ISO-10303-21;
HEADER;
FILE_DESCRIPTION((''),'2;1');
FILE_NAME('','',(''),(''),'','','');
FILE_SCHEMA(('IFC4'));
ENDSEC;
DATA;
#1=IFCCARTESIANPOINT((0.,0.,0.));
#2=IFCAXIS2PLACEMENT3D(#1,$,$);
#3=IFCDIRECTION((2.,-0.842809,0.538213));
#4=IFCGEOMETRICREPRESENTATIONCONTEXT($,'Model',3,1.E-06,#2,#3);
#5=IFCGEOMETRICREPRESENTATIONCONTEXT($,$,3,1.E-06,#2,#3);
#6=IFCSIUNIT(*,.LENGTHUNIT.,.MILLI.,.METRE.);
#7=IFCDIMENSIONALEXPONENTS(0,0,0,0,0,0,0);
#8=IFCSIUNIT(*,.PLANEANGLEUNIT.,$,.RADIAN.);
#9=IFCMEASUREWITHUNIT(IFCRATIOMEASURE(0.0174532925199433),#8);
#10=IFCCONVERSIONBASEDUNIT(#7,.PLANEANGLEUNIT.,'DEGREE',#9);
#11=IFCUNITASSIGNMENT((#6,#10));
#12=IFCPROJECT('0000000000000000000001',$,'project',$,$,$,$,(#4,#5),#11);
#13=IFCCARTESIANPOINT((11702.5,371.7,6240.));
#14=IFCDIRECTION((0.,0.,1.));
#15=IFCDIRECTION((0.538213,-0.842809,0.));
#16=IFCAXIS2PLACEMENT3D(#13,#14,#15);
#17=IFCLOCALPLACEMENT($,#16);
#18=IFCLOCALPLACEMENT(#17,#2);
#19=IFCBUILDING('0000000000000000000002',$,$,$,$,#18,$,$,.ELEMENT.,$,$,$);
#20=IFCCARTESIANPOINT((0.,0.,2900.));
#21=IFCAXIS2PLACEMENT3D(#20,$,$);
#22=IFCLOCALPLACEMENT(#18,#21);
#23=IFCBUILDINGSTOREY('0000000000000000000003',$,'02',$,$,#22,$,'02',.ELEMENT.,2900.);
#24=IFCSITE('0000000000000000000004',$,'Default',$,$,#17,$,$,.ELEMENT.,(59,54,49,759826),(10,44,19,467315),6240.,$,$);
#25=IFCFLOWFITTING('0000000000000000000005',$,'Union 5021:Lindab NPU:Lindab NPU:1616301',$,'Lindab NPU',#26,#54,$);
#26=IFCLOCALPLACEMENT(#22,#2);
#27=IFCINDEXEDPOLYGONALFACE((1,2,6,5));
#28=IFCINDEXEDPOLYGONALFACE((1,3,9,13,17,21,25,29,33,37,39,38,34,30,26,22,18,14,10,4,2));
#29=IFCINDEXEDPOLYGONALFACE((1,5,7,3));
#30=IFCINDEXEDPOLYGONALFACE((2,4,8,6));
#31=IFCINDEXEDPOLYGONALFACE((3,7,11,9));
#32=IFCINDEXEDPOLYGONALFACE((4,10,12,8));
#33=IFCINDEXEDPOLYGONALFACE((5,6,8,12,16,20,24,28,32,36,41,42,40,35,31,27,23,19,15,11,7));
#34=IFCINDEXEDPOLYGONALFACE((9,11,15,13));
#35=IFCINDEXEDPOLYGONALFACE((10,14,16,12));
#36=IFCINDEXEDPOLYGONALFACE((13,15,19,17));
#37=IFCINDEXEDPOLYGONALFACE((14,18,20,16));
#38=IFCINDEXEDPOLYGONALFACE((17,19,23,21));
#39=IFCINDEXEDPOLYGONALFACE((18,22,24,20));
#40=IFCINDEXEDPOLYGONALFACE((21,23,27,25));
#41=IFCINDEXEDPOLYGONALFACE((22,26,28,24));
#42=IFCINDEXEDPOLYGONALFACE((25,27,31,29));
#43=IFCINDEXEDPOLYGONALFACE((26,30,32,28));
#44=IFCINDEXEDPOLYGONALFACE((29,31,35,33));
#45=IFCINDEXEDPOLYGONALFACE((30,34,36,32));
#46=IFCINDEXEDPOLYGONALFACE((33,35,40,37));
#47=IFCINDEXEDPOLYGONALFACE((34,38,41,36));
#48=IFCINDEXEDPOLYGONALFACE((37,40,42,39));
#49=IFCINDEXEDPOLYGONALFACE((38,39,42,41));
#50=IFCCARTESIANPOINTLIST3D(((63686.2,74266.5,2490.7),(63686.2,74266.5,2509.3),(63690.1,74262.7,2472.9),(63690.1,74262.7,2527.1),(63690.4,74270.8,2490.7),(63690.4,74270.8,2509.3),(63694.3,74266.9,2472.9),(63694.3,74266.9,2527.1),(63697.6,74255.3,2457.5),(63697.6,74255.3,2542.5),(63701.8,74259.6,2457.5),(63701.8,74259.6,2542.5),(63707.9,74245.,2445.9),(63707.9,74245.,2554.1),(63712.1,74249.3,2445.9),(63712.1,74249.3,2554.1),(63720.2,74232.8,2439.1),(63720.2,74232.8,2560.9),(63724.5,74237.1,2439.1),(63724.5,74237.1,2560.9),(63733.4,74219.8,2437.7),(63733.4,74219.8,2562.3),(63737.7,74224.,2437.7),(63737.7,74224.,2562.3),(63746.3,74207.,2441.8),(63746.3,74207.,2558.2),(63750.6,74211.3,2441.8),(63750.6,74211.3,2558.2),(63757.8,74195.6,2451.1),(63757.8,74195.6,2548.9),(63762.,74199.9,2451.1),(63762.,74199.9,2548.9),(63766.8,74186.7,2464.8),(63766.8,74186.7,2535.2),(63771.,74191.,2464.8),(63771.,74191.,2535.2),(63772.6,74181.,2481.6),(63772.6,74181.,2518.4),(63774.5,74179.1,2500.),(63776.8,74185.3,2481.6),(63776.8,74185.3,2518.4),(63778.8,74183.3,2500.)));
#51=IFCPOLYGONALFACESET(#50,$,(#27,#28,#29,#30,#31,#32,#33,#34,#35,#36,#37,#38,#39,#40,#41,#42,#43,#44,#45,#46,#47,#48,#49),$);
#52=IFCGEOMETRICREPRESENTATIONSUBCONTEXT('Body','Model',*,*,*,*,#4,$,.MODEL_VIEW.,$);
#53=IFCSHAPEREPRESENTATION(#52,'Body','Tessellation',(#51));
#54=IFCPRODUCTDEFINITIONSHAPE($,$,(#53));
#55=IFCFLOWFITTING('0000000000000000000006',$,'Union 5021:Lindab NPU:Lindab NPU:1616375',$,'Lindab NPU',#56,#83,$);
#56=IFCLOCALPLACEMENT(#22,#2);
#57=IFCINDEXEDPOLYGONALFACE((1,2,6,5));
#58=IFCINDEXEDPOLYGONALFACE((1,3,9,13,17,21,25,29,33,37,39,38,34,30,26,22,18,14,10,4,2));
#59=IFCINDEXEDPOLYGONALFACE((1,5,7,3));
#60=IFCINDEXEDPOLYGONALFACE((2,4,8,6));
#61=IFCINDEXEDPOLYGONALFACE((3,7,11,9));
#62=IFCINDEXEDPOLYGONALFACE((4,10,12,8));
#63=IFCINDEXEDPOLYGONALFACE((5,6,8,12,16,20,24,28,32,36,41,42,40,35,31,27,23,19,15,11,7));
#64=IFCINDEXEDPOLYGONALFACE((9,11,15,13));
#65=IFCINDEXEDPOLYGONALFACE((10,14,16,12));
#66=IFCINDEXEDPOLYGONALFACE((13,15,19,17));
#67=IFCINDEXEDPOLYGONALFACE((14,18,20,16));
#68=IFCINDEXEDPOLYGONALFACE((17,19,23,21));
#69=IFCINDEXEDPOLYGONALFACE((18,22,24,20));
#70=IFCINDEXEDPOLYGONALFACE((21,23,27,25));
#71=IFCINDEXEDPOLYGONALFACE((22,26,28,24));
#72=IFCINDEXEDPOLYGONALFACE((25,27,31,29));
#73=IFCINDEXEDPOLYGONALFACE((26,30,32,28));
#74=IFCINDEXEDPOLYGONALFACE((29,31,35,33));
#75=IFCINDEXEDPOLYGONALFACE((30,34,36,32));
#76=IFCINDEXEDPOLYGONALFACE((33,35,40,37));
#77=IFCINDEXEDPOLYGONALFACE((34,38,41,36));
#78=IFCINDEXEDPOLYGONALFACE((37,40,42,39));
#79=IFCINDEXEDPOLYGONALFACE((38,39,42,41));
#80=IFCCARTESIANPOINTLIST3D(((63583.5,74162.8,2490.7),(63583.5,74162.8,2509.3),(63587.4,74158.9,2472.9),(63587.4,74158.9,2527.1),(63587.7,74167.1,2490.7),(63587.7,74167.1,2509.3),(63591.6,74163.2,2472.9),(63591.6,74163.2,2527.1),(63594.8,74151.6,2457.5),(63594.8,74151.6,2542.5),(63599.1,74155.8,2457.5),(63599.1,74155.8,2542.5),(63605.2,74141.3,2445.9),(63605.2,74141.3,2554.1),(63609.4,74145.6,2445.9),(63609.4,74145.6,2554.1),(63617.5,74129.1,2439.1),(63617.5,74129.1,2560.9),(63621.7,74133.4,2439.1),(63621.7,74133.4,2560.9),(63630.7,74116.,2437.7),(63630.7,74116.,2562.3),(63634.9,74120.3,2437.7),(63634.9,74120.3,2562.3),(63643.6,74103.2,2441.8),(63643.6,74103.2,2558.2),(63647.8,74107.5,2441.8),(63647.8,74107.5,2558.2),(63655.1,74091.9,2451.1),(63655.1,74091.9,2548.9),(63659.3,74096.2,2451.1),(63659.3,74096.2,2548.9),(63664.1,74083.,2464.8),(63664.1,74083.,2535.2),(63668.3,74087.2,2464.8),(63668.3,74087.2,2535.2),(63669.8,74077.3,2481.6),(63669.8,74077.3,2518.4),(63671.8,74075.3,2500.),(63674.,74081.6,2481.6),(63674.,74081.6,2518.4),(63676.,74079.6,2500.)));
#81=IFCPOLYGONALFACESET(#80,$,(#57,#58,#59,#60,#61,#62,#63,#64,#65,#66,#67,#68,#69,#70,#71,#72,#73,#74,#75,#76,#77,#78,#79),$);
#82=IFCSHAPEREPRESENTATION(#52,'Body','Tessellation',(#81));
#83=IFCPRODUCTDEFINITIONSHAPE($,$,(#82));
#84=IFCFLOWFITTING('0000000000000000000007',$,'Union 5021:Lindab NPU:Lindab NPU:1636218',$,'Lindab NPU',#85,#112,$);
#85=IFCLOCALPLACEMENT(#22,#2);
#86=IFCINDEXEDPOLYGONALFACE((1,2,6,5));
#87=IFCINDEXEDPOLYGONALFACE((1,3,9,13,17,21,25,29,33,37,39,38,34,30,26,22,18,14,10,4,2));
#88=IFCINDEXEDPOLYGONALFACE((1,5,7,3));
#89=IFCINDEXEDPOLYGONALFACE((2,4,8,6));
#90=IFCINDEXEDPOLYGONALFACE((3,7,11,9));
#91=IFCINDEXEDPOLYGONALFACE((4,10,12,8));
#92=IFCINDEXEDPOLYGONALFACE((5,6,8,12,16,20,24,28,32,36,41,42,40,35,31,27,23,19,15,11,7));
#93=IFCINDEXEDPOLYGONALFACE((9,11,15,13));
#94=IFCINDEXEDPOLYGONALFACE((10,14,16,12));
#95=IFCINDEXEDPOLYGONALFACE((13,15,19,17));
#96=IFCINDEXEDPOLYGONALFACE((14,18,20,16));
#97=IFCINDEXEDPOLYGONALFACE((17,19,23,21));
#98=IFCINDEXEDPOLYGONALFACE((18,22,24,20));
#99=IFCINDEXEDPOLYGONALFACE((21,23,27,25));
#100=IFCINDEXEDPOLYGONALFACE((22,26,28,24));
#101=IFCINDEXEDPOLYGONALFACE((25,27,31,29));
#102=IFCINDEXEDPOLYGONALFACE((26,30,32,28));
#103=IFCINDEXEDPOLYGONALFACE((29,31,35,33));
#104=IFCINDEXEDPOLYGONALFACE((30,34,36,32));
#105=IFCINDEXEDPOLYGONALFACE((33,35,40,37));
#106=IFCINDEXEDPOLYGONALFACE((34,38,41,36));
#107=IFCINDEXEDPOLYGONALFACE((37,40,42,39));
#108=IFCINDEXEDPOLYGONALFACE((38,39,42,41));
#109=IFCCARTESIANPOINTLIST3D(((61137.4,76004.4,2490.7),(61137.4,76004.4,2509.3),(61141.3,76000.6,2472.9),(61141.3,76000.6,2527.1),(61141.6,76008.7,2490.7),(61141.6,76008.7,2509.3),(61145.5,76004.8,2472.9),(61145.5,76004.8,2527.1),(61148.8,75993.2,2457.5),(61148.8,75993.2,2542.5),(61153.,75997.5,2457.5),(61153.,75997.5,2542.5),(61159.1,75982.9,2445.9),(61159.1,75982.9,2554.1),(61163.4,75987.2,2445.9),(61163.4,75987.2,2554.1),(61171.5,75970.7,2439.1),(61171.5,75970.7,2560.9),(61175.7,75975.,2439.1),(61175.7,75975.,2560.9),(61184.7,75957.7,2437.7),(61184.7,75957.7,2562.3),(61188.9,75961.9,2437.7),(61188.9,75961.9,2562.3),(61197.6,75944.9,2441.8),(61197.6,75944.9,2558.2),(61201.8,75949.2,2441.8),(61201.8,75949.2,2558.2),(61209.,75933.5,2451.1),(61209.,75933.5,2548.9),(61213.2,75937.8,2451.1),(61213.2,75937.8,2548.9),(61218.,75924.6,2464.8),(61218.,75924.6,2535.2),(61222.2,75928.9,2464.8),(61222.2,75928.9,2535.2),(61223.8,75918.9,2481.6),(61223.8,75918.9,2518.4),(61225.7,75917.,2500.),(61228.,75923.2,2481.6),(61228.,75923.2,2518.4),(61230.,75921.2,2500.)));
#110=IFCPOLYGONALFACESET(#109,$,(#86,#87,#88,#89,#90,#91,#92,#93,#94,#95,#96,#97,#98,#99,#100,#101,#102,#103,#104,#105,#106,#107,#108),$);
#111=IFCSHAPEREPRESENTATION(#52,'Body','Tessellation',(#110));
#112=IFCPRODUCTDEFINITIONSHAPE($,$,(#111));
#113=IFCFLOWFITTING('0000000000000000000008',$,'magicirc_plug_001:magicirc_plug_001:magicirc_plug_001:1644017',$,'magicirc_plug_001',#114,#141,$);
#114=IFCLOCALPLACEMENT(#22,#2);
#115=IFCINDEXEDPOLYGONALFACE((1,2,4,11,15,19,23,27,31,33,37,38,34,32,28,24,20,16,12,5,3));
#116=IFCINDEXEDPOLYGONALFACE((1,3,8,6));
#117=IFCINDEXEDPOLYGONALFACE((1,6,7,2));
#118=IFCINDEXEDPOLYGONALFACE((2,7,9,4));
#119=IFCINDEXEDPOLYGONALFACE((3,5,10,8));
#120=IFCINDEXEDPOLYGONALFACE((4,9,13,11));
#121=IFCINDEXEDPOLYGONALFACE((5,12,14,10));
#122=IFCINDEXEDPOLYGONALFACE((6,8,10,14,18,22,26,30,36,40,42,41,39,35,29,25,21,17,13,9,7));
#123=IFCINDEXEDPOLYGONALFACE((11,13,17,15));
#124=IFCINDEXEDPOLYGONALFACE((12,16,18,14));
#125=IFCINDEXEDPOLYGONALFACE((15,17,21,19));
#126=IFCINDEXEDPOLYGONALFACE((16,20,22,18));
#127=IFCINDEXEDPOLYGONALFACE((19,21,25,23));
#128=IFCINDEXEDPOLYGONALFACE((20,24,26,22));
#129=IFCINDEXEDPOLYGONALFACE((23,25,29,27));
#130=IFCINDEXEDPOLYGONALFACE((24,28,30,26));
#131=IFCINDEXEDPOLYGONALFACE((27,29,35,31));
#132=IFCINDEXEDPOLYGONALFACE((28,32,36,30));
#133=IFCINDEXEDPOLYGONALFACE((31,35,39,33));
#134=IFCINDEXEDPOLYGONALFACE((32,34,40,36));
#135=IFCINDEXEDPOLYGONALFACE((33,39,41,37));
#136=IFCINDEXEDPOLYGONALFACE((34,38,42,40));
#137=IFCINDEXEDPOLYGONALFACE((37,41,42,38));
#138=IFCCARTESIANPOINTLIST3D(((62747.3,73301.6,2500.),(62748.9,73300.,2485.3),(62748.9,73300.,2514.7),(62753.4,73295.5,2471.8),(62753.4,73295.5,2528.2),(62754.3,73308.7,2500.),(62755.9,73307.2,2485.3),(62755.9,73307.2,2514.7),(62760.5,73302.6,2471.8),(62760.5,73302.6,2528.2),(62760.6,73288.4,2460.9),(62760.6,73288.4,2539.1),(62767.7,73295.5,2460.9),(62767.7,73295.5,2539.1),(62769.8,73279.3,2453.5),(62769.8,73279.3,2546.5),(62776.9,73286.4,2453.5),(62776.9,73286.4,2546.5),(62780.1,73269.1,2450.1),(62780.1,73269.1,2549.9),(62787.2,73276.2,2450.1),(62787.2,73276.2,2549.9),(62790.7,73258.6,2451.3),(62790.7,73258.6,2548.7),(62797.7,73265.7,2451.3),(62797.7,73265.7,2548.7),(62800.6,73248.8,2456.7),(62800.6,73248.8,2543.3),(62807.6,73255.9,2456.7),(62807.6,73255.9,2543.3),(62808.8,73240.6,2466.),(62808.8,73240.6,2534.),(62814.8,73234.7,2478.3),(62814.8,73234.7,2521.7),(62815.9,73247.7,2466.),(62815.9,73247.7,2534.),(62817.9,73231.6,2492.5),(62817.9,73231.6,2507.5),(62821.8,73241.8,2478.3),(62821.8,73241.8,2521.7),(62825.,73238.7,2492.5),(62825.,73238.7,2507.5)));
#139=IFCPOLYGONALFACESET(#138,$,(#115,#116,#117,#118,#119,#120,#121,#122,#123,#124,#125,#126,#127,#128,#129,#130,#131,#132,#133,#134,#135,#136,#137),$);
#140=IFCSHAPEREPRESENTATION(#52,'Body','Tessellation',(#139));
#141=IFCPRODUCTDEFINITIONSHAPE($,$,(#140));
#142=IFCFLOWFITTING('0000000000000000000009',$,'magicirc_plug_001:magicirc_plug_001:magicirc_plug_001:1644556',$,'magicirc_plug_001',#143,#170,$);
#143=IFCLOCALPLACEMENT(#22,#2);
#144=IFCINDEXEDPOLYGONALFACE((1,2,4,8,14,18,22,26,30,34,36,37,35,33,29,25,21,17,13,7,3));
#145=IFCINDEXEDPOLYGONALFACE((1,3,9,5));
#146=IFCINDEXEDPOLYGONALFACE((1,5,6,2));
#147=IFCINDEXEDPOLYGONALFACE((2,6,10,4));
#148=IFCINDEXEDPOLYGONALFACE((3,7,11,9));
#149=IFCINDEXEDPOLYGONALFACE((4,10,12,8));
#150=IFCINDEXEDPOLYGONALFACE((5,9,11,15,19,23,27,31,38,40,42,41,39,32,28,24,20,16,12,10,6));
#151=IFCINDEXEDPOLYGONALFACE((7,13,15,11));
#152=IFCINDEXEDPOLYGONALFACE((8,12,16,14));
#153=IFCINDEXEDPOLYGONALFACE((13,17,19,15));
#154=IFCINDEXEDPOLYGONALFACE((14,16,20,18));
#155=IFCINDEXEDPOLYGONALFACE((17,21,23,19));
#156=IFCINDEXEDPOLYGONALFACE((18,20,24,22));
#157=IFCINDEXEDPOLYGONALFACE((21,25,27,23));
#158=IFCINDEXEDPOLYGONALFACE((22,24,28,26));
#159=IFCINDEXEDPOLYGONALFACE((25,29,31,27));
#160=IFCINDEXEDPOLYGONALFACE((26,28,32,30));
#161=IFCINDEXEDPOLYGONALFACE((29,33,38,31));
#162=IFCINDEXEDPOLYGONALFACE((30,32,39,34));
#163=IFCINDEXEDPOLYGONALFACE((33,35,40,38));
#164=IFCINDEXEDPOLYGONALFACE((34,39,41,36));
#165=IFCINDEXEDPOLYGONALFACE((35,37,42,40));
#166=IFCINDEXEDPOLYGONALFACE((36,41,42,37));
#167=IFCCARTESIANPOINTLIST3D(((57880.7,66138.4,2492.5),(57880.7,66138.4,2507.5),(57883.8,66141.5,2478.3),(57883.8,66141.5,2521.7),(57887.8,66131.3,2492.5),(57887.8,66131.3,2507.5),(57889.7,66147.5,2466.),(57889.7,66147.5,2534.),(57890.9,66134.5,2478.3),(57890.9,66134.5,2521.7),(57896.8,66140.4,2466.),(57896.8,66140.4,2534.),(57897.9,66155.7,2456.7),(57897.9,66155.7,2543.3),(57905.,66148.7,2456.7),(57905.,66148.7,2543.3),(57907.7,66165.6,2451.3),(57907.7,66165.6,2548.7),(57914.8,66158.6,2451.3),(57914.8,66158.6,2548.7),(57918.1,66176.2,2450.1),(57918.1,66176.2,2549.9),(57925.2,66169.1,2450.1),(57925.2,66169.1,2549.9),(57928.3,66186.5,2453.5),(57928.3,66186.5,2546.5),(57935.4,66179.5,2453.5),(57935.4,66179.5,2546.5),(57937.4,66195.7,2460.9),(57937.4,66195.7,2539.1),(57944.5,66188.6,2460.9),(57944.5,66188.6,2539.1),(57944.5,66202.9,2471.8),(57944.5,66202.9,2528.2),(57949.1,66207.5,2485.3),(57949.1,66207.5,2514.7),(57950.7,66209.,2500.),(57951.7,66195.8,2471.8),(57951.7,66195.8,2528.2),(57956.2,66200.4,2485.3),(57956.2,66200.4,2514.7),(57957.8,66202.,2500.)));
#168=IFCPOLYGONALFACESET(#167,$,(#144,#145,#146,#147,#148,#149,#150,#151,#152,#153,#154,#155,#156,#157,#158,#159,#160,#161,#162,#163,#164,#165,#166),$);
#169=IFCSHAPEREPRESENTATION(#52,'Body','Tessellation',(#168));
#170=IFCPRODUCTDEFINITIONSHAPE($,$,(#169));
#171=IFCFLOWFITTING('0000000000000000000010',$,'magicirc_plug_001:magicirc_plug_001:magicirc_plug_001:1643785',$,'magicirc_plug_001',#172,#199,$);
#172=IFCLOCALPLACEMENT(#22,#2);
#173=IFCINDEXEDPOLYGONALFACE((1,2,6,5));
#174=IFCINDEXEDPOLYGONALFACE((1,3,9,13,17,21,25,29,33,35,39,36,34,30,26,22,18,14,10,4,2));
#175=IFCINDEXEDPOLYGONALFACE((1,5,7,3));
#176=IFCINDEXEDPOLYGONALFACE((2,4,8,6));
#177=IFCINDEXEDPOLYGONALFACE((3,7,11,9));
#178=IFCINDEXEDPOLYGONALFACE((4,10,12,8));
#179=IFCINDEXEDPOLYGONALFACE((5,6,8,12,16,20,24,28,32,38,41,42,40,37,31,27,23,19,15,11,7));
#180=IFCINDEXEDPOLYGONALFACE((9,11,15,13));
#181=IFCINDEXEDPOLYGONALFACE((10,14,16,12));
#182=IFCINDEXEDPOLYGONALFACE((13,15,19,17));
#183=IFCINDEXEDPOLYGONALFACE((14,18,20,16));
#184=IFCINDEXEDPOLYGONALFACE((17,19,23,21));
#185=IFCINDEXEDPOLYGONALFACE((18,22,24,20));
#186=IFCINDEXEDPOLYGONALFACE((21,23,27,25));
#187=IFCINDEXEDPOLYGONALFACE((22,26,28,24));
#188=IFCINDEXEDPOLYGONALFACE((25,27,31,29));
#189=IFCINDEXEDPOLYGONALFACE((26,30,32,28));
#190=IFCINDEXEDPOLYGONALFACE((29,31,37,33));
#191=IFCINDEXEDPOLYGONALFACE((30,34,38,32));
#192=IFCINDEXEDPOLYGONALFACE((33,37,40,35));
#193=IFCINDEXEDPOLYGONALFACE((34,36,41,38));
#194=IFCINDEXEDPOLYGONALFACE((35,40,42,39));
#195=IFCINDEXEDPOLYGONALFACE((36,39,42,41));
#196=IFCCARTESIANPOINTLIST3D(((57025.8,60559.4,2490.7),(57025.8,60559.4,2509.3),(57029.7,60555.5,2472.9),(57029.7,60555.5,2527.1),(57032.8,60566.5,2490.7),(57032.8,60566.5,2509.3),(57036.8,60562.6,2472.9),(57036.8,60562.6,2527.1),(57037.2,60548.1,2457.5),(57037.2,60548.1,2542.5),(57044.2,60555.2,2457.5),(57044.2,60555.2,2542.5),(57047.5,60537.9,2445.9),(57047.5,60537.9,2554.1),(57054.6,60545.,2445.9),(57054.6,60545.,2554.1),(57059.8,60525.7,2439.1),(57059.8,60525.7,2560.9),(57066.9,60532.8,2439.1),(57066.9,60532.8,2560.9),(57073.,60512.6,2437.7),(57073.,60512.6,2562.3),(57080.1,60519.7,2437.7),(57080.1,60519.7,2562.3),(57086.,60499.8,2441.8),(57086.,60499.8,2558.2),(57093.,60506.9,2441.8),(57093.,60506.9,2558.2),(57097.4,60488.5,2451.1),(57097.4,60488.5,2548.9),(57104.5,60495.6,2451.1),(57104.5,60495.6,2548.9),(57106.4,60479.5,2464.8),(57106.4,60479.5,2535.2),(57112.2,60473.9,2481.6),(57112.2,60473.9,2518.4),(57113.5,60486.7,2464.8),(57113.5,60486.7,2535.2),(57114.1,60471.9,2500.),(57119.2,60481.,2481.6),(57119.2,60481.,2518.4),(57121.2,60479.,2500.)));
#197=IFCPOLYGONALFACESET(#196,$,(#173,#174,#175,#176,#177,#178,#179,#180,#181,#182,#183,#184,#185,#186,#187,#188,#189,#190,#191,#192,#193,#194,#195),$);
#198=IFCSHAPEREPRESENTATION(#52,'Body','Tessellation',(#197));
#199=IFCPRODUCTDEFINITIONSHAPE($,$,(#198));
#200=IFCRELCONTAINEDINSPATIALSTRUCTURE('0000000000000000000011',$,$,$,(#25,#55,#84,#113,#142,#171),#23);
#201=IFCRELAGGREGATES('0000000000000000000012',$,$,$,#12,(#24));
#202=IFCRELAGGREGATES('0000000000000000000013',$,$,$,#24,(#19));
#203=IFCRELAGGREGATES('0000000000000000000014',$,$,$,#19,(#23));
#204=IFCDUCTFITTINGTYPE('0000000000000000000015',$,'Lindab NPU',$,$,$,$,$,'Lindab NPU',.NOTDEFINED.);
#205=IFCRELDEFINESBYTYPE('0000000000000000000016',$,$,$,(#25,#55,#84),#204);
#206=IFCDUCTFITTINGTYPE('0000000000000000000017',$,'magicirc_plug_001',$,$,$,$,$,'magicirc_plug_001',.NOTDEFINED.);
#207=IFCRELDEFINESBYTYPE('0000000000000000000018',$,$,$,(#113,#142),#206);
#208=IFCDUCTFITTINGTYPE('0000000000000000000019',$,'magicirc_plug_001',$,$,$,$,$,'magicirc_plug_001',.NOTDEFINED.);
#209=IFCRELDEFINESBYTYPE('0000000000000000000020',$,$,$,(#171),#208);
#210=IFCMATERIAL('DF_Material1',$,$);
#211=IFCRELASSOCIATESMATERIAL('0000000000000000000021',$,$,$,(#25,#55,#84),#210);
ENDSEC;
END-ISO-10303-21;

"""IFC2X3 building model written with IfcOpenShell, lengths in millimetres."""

from ifc_helpers import new_model, entity, si_unit, converted_unit, direction, frame, frame_2d, origin, place, context, subcontext, project, spatial, circle, extrude, source, transform, mapped, material, type_object, type_shapes, element, save


model = new_model("IFC2X3")

# Units and contexts
model_context = context("Model", 3, precision=1e-06, world=origin(), true_north=direction((2.0, -0.842809, 0.538213)))
context_of_model = context(None, 3, precision=1e-06, world=origin(), true_north=direction((2.0, -0.842809, 0.538213)))
body_context = subcontext(model_context, "Body", "Model", "MODEL_VIEW")
ifc_project = project(units=[si_unit("LENGTHUNIT", "METRE", prefix="MILLI"), converted_unit("PLANEANGLEUNIT", "DEGREE", entity("IfcRatioMeasure", 0.0174532925199433), si_unit("PLANEANGLEUNIT", "RADIAN"), dimensions=[0, 0, 0, 0, 0, 0, 0])], contexts=[model_context, context_of_model])

# Site, building, storey
site_placement = place(None, frame((11702.5, 371.7, 6240.0), z_axis=(0.0, 0.0, 1.0), x_axis=(0.538213, -0.842809, 0.0)))
site = spatial("IfcSite", under=ifc_project, at=site_placement, Name="Default", CompositionType="ELEMENT", RefLatitude=(59, 54, 49, 759826), RefLongitude=(10, 44, 19, 467315), RefElevation=6240.0)
building_placement = place(site_placement, origin())
building = spatial("IfcBuilding", under=site, at=building_placement, CompositionType="ELEMENT")
storey_placement = place(building_placement, frame((0.0, 0.0, 2900.0)))
storey = spatial("IfcBuildingStorey", under=building, at=storey_placement, Name="02", LongName="02", CompositionType="ELEMENT", Elevation=2900.0)

# Flow fittings
ifc_material = material(Name="DF_Material1")
duct_fitting_type_1 = type_object("IfcDuctFittingType", Name="Lindab NPU", ElementType="Lindab NPU", PredefinedType="NOTDEFINED")
shared_shape_1 = source(origin(), body_context, "Body", "SweptSolid", [
    extrude(circle(Radius=62.5, at=frame_2d((0.0, 0.0), x_axis=(1.0, 0.0))), frame((0.0, 0.0, 0.0), z_axis=(1.0, 0.0, 0.0), x_axis=(0.0, 1.0, 0.0)), (0.0, 0.0, 1.0), 6.0),
])
type_shapes(duct_fitting_type_1, [shared_shape_1])
for number, where, z_axis, x_axis, name in (
    (1, (63734.3, 74227.3, 2500.0), (0.0, 0.0, 1.0), (-0.703643, -0.710554, 0.0), "Union 5021:Lindab NPU:Lindab NPU:1616301"),
    (2, (63631.6, 74123.6, 2500.0), (0.0, 0.0, 1.0), (-0.703643, -0.710554, 0.0), "Union 5021:Lindab NPU:Lindab NPU:1616375"),
    (3, (61185.6, 75965.2, 2500.0), (0.0, 0.0, 1.0), (-0.703643, -0.710554, 0.0), "Union 5021:Lindab NPU:Lindab NPU:1636218"),
):
    element("IfcFlowFitting", number, at=place(storey_placement, frame(where, z_axis=z_axis, x_axis=x_axis)), inside=storey, type_object=duct_fitting_type_1, material=ifc_material, Name=name, ObjectType="Lindab NPU", context=body_context, shape_type="MappedRepresentation", body=[
        mapped(shared_shape_1, transform((0.0, 0.0, 0.0), scale=1.0)),
    ])

# Flow fittings
duct_fitting_type_2 = type_object("IfcDuctFittingType", Name="magicirc_plug_001", ElementType="magicirc_plug_001", PredefinedType="NOTDEFINED")
shared_shape_2 = source(origin(), body_context, "Body", "SweptSolid", [
    extrude(circle(Radius=50.0, at=frame_2d((0.0, 0.0), x_axis=(1.0, 0.0))), frame((0.0, 0.0, 0.0), z_axis=(1.0, 0.0, 0.0), x_axis=(0.0, 1.0, 0.0)), (0.0, 0.0, 1.0), 10.0),
])
type_shapes(duct_fitting_type_2, [shared_shape_2])
for number, where, z_axis, x_axis, name in (
    (4, (62782.8, 73266.4, 2500.0), (0.0, 0.0, 1.0), (0.703643, 0.710554, 0.0), "magicirc_plug_001:magicirc_plug_001:magicirc_plug_001:1644017"),
    (5, (57915.5, 66173.5, 2500.0), (0.0, 0.0, 1.0), (0.710554, -0.703643, 0.0), "magicirc_plug_001:magicirc_plug_001:magicirc_plug_001:1644556"),
):
    element("IfcFlowFitting", number, at=place(storey_placement, frame(where, z_axis=z_axis, x_axis=x_axis)), inside=storey, type_object=duct_fitting_type_2, Name=name, ObjectType="magicirc_plug_001", context=body_context, shape_type="MappedRepresentation", body=[
        mapped(shared_shape_2, transform((0.0, 0.0, 0.0), scale=1.0)),
    ])
duct_fitting_type_3 = type_object("IfcDuctFittingType", Name="magicirc_plug_001", ElementType="magicirc_plug_001", PredefinedType="NOTDEFINED")
shared_shape_3 = source(origin(), body_context, "Body", "SweptSolid", [
    extrude(circle(Radius=62.5, at=frame_2d((0.0, 0.0), x_axis=(1.0, 0.0))), frame((0.0, 0.0, 0.0), z_axis=(1.0, 0.0, 0.0), x_axis=(0.0, 1.0, 0.0)), (0.0, 0.0, 1.0), 10.0),
])
type_shapes(duct_fitting_type_3, [shared_shape_3])
for number, where, z_axis, x_axis, name in (
    (6, (57076.8, 60523.0, 2500.0), (0.0, 0.0, 1.0), (-0.703643, -0.710554, 0.0), "magicirc_plug_001:magicirc_plug_001:magicirc_plug_001:1643785"),
):
    element("IfcFlowFitting", number, at=place(storey_placement, frame(where, z_axis=z_axis, x_axis=x_axis)), inside=storey, type_object=duct_fitting_type_3, Name=name, ObjectType="magicirc_plug_001", context=body_context, shape_type="MappedRepresentation", body=[
        mapped(shared_shape_3, transform((0.0, 0.0, 0.0), scale=1.0)),
    ])

save(model, "model.ifc")
